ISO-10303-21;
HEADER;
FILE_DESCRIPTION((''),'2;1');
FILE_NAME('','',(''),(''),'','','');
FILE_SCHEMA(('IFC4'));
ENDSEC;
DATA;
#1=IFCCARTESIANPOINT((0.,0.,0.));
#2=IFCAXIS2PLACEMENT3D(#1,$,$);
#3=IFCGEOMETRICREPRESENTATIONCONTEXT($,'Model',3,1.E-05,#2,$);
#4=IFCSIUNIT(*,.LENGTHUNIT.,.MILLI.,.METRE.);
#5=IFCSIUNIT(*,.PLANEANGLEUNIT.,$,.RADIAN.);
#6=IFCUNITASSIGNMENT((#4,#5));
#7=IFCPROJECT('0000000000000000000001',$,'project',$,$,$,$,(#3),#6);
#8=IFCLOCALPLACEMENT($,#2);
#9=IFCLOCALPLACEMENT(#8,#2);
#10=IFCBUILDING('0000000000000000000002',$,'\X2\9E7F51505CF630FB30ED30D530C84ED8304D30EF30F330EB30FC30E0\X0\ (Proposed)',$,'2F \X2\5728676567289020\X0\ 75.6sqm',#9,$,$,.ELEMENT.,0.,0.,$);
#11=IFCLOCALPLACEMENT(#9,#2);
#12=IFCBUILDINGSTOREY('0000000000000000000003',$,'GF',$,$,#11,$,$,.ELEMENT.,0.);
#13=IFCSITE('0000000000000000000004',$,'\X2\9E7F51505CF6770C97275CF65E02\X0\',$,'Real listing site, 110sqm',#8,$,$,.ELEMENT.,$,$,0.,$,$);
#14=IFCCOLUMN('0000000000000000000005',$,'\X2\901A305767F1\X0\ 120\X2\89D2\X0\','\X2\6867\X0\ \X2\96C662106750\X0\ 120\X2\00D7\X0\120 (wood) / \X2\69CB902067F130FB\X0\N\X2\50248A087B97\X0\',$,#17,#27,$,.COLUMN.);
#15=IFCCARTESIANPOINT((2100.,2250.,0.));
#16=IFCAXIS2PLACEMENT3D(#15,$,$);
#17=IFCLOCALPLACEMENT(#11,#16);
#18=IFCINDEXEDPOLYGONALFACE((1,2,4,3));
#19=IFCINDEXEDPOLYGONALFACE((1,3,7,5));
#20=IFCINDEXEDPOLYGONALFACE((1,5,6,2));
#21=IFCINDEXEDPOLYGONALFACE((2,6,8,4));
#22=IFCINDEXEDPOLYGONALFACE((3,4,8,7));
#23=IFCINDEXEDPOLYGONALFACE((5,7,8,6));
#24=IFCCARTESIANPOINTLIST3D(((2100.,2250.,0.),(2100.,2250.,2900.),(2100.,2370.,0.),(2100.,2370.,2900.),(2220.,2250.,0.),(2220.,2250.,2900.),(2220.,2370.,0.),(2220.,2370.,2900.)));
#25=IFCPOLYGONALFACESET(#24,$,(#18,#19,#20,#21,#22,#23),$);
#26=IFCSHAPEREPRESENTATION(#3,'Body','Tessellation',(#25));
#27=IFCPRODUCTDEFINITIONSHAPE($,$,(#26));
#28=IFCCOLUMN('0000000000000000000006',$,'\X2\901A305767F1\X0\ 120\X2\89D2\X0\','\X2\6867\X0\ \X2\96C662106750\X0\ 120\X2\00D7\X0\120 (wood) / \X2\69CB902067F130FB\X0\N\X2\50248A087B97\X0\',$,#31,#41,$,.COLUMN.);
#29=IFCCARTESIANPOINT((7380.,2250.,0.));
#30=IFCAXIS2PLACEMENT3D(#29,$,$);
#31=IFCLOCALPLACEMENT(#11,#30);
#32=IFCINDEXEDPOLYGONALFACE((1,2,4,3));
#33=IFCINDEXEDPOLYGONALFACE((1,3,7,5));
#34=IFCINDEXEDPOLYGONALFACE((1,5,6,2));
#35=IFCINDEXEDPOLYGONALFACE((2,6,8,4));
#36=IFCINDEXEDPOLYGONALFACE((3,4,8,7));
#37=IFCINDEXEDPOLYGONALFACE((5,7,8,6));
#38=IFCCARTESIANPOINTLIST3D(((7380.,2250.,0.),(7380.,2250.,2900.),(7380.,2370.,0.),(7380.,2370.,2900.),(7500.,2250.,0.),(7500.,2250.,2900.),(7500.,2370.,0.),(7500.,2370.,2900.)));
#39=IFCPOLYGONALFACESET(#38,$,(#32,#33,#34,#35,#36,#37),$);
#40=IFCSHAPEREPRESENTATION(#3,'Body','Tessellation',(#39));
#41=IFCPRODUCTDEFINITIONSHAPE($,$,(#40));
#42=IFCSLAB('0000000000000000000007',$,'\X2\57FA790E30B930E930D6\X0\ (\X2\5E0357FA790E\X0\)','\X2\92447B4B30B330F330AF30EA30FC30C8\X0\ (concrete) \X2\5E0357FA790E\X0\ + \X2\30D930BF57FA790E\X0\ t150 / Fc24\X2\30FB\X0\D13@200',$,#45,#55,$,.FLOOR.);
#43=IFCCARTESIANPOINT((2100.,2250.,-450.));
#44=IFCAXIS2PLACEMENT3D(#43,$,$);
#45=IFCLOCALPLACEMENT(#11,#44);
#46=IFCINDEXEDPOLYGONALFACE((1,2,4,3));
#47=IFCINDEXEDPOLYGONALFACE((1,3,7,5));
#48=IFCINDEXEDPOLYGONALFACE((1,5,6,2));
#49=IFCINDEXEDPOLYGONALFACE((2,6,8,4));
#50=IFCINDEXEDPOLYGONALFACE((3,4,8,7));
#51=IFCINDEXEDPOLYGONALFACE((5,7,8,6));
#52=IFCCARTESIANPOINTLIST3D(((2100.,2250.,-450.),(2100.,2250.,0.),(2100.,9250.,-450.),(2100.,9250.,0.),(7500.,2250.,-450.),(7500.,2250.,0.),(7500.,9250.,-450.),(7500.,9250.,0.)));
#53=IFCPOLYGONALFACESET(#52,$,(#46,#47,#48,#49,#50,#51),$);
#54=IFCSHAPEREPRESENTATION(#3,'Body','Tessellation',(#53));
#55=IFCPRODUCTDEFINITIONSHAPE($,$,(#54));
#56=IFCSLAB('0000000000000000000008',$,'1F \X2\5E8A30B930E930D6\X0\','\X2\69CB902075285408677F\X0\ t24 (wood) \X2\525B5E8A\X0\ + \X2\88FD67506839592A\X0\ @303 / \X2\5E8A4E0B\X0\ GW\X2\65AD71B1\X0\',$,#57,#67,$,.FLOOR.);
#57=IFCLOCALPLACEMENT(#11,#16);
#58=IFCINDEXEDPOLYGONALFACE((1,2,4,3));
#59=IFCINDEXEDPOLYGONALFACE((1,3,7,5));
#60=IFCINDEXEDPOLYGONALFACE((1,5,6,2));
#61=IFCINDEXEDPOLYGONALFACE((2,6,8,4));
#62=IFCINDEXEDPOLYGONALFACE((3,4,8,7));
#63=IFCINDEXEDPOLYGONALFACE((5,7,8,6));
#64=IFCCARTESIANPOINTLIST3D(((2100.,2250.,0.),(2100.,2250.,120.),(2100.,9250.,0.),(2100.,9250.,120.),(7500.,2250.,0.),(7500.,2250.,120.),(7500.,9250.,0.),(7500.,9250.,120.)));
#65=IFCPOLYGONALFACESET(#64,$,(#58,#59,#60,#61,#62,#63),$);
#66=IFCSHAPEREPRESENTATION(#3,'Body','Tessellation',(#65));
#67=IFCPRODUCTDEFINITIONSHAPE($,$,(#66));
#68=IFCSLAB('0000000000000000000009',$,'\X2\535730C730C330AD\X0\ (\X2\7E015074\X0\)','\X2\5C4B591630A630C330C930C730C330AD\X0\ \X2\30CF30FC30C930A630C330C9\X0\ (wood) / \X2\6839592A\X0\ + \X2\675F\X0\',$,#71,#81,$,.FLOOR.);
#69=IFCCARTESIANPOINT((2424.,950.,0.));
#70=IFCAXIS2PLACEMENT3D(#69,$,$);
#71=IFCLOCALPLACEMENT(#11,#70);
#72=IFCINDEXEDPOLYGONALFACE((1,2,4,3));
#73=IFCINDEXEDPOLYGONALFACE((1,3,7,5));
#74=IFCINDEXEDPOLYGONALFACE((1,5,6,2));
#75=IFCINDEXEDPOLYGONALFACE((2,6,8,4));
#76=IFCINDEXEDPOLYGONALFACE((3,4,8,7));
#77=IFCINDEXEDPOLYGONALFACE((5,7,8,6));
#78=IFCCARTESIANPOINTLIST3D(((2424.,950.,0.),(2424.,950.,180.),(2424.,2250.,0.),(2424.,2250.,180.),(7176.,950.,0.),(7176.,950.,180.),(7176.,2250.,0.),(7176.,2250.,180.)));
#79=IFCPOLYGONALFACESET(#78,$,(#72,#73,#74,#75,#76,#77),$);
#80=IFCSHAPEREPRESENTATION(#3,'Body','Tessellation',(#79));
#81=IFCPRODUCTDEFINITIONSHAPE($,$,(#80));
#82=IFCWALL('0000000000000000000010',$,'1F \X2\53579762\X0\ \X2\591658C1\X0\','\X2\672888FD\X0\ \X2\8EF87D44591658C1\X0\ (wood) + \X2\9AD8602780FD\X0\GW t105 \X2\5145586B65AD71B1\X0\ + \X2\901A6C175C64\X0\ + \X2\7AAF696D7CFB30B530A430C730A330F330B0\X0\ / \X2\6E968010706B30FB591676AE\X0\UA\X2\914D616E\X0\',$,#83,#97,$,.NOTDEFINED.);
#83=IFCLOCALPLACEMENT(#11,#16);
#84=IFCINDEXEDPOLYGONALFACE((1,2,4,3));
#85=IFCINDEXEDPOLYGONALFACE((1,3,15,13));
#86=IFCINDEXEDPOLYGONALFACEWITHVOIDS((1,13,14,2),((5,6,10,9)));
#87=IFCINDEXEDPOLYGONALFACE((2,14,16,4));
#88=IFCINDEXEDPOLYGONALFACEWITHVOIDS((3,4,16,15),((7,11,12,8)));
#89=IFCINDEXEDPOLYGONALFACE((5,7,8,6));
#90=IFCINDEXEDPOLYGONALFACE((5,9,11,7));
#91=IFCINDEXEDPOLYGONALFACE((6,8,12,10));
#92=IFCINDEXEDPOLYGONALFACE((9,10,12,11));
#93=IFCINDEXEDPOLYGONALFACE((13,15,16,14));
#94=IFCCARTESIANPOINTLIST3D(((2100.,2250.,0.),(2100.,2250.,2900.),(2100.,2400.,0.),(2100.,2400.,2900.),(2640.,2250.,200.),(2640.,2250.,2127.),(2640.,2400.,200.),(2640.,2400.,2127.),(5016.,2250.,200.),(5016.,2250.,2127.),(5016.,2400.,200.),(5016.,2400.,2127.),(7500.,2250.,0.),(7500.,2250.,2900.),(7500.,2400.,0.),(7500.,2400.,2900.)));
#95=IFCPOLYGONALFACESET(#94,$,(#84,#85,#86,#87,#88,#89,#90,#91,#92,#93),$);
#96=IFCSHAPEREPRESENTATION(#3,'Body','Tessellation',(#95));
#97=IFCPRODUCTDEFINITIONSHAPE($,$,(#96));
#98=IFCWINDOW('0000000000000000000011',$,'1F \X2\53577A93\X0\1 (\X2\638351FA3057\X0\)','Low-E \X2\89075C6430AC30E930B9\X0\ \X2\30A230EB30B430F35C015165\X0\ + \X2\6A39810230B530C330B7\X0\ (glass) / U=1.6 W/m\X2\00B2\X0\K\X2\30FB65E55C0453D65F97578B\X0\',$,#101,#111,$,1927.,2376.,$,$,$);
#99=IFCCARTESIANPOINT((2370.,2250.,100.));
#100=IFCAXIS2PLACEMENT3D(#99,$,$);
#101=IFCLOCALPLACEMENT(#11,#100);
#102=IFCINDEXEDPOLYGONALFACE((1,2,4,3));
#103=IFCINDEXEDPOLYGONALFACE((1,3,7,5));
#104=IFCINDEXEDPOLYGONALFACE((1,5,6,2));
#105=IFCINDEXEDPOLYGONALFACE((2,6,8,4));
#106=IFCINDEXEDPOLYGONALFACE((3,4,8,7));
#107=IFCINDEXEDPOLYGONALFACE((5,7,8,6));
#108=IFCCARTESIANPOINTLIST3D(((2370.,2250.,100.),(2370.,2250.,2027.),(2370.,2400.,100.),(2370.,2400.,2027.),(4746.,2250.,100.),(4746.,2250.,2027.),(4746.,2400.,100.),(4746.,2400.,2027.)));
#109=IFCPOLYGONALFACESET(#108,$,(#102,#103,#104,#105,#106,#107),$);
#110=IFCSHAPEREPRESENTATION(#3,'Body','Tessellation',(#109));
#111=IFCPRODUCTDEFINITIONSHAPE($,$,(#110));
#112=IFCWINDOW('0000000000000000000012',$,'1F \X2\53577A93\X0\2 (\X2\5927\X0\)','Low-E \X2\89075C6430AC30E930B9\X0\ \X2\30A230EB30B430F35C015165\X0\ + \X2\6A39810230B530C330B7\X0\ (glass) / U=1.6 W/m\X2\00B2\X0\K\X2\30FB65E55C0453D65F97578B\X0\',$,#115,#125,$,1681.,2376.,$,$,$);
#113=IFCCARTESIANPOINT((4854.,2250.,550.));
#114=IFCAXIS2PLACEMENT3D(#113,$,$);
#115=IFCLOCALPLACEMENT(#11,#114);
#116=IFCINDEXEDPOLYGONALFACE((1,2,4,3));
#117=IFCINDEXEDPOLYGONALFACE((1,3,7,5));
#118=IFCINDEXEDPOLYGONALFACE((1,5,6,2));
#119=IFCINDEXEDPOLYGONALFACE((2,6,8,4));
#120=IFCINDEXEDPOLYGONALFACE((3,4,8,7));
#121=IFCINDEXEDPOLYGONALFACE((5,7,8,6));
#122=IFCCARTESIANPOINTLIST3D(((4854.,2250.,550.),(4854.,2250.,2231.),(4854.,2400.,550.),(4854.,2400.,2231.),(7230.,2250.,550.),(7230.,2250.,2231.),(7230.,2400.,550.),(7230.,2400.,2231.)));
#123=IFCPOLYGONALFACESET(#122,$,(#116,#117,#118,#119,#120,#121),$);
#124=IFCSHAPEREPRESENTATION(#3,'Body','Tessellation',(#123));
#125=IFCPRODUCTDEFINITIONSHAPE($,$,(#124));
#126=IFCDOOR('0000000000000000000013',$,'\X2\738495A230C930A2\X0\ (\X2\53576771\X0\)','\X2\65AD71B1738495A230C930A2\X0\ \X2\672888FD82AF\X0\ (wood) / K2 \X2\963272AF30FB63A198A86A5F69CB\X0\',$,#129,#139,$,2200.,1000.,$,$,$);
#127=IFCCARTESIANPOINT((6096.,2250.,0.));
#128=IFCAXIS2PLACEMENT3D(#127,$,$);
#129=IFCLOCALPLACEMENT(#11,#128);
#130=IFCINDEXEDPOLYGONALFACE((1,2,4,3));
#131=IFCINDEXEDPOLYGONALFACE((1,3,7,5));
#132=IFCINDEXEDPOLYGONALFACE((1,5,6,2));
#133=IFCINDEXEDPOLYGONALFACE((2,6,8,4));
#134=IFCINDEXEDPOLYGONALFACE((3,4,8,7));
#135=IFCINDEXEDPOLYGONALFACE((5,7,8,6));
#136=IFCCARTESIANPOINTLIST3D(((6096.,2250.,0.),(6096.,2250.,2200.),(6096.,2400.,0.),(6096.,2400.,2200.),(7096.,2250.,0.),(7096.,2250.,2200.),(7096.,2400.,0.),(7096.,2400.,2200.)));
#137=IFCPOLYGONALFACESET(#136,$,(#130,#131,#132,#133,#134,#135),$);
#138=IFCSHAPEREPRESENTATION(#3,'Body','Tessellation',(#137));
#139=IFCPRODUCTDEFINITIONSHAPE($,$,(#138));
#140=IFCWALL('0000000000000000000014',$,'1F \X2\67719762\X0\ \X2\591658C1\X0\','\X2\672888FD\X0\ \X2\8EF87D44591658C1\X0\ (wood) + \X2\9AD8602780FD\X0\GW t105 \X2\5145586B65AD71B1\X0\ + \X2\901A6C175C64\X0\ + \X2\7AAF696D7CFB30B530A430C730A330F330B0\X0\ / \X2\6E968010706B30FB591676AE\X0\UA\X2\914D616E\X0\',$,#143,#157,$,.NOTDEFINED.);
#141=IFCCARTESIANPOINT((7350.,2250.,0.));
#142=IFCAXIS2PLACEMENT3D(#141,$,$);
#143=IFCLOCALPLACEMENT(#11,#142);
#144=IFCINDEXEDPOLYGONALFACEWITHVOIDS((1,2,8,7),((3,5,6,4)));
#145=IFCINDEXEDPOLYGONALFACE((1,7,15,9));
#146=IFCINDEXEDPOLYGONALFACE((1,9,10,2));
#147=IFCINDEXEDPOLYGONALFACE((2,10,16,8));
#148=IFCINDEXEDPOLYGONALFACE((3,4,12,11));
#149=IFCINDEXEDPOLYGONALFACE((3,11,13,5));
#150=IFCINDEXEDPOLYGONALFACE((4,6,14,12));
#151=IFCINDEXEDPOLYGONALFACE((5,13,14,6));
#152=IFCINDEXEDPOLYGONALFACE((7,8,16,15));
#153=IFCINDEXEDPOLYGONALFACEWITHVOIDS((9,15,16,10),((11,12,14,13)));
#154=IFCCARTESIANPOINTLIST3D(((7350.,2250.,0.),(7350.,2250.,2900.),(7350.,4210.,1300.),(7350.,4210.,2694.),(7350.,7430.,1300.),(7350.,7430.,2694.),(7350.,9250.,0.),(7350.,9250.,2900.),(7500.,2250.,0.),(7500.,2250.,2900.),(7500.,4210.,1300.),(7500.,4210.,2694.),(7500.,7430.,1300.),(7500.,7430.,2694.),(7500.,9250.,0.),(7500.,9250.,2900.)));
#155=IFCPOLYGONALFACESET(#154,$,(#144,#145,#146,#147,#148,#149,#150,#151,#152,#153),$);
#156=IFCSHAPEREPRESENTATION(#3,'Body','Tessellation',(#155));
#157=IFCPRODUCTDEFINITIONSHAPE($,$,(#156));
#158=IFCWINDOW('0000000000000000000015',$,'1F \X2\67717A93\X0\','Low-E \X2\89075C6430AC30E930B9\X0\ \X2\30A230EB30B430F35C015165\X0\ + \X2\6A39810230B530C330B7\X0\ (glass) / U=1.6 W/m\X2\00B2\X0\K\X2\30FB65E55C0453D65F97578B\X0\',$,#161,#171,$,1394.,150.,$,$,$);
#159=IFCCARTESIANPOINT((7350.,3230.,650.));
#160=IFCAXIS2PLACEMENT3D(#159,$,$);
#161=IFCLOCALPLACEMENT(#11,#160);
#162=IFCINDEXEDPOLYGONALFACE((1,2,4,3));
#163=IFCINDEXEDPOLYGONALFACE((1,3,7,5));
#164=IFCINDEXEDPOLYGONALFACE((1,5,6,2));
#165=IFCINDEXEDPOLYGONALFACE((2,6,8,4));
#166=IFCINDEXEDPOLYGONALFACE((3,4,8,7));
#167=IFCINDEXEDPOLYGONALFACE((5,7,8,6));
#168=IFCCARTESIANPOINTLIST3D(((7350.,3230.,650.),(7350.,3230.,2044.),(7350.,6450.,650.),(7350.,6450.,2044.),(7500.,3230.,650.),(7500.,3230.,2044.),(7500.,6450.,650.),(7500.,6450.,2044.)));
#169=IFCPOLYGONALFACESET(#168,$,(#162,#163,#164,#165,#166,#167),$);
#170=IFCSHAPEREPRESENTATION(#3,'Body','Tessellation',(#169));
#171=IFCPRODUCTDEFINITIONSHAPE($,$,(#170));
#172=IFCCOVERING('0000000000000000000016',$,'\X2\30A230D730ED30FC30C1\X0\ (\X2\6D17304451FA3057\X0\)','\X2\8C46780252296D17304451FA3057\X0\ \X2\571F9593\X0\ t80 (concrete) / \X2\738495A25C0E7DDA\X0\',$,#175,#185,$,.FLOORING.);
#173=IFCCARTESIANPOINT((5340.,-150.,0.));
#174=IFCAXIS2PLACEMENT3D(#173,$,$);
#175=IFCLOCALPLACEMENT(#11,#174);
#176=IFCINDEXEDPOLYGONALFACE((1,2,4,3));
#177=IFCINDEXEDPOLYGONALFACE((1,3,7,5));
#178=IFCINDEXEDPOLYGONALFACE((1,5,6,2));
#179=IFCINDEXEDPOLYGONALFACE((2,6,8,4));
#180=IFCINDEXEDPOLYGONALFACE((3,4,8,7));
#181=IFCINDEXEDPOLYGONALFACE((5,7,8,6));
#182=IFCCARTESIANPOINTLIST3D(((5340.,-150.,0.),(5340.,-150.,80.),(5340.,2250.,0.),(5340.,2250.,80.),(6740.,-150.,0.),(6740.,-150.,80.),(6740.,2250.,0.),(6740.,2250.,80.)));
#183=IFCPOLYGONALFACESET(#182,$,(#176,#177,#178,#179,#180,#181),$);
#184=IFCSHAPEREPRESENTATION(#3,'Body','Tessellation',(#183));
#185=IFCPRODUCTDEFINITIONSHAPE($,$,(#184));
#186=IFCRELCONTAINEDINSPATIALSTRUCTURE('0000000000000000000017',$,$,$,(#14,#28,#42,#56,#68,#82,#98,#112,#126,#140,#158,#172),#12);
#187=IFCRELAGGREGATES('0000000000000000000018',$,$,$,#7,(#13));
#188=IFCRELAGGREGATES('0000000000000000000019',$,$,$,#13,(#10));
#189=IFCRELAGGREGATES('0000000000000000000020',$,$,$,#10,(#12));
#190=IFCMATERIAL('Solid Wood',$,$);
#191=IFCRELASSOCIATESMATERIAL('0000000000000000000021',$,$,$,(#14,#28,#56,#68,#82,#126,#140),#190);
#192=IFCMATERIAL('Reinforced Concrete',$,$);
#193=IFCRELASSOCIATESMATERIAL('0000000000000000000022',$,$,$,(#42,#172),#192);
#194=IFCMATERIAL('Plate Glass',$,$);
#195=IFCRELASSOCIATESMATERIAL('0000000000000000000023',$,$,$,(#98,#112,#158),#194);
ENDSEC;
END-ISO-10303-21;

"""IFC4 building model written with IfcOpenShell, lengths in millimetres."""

from ifc_helpers import new_model, si_unit, frame, frame_2d, origin, place, context, project, spatial, rectangle, extrude, material, element, fill, save


model = new_model("IFC4")

# Units and contexts
model_context = context("Model", 3, precision=1e-05, world=origin())
ifc_project = project(units=[si_unit("LENGTHUNIT", "METRE", prefix="MILLI"), si_unit("PLANEANGLEUNIT", "RADIAN")], contexts=[model_context])

# Site, building, storey
site_placement = place(None, origin())
site = spatial("IfcSite", under=ifc_project, at=site_placement, Name="鹿児島県霧島市", ObjectType="Real listing site, 110sqm", CompositionType="ELEMENT", RefElevation=0.0)
building_placement = place(site_placement, origin())
building = spatial("IfcBuilding", under=site, at=building_placement, Name="鹿児島・ロフト付きワンルーム (Proposed)", ObjectType="2F 在来木造 75.6sqm", CompositionType="ELEMENT", ElevationOfRefHeight=0.0, ElevationOfTerrain=0.0)
storey_placement = place(building_placement, origin())
storey = spatial("IfcBuildingStorey", under=building, at=storey_placement, Name="GF", CompositionType="ELEMENT", Elevation=0.0)

# Columns
ifc_material_1 = material(Name="Solid Wood")
column_1_placement = place(storey_placement, frame((2100.0, 2250.0, 0.0)))
element("IfcColumn", 1, at=column_1_placement, inside=storey, material=ifc_material_1, Name="通し柱 120角", Description="桧 集成材 120×120 (wood) / 構造柱・N値計算", PredefinedType="COLUMN", context=model_context, shape_type="SweptSolid", body=[
    extrude(rectangle(XDim=120.0, YDim=120.0, at=frame_2d((60.0, 60.0))), frame((2100.0, 2250.0, 0.0)), (0.0, 0.0, 1.0), 2900.0),
])
column_2_placement = place(storey_placement, frame((7380.0, 2250.0, 0.0)))
element("IfcColumn", 2, at=column_2_placement, inside=storey, material=ifc_material_1, Name="通し柱 120角", Description="桧 集成材 120×120 (wood) / 構造柱・N値計算", PredefinedType="COLUMN", context=model_context, shape_type="SweptSolid", body=[
    extrude(rectangle(XDim=120.0, YDim=120.0, at=frame_2d((60.0, 60.0))), frame((7380.0, 2250.0, 0.0)), (0.0, 0.0, 1.0), 2900.0),
])

# Slabs
ifc_material_2 = material(Name="Reinforced Concrete")
slab_1_placement = place(storey_placement, frame((2100.0, 2250.0, -450.0)))
element("IfcSlab", 3, at=slab_1_placement, inside=storey, material=ifc_material_2, Name="基礎スラブ (布基礎)", Description="鉄筋コンクリート (concrete) 布基礎 + ベタ基礎 t150 / Fc24・D13@200", PredefinedType="FLOOR", context=model_context, shape_type="SweptSolid", body=[
    extrude(rectangle(XDim=5400.0, YDim=7000.0, at=frame_2d((2700.0, 3500.0))), frame((2100.0, 2250.0, -450.0)), (0.0, 0.0, 1.0), 450.0),
])
slab_2_placement = place(storey_placement, frame((2100.0, 2250.0, 0.0)))
element("IfcSlab", 4, at=slab_2_placement, inside=storey, material=ifc_material_1, Name="1F 床スラブ", Description="構造用合板 t24 (wood) 剛床 + 製材根太 @303 / 床下 GW断熱", PredefinedType="FLOOR", context=model_context, shape_type="SweptSolid", body=[
    extrude(rectangle(XDim=5400.0, YDim=7000.0, at=frame_2d((2700.0, 3500.0))), frame((2100.0, 2250.0, 0.0)), (0.0, 0.0, 1.0), 120.0),
])
slab_3_placement = place(storey_placement, frame((2424.0, 950.0, 0.0)))
element("IfcSlab", 5, at=slab_3_placement, inside=storey, material=ifc_material_1, Name="南デッキ (縁側)", Description="屋外ウッドデッキ ハードウッド (wood) / 根太 + 束", PredefinedType="FLOOR", context=model_context, shape_type="SweptSolid", body=[
    extrude(rectangle(XDim=4752.0, YDim=1300.0, at=frame_2d((2376.0, 650.0))), frame((2424.0, 950.0, 0.0)), (0.0, 0.0, 1.0), 180.0),
])

# Wall, openings, windows, door
wall_1_placement = place(storey_placement, frame((2100.0, 2250.0, 0.0)))
wall_1 = element("IfcWall", 6, at=wall_1_placement, inside=storey, material=ifc_material_1, Name="1F 南面 外壁", Description="木製 軸組外壁 (wood) + 高性能GW t105 充填断熱 + 通気層 + 窯業系サイディング / 準耐火・外皮UA配慮", PredefinedType="NOTDEFINED", context=model_context, shape_type="SweptSolid", body=[
    extrude(rectangle(XDim=5400.0, YDim=150.0, at=frame_2d((2700.0, 75.0))), frame((2100.0, 2250.0, 0.0)), (0.0, 0.0, 1.0), 2900.0),
])
opening_1_placement = place(storey_placement, frame((2370.0, 2250.0, 100.0)))
opening_1 = element("IfcOpeningElement", 7, at=opening_1_placement, cuts=wall_1, PredefinedType="NOTDEFINED", context=model_context, shape_type="SweptSolid", body=[
    extrude(rectangle(XDim=2376.0, YDim=150.0, at=frame_2d((1188.0, 75.0))), frame((2370.0, 2250.0, 100.0)), (0.0, 0.0, 1.0), 1927.0),
])
opening_2_placement = place(storey_placement, frame((4854.0, 2250.0, 550.0)))
opening_2 = element("IfcOpeningElement", 8, at=opening_2_placement, cuts=wall_1, PredefinedType="NOTDEFINED", context=model_context, shape_type="SweptSolid", body=[
    extrude(rectangle(XDim=2376.0, YDim=150.0, at=frame_2d((1188.0, 75.0))), frame((4854.0, 2250.0, 550.0)), (0.0, 0.0, 1.0), 1681.0),
])
opening_3_placement = place(storey_placement, frame((6096.0, 2250.0, 0.0)))
opening_3 = element("IfcOpeningElement", 9, at=opening_3_placement, cuts=wall_1, PredefinedType="NOTDEFINED", context=model_context, shape_type="SweptSolid", body=[
    extrude(rectangle(XDim=1000.0, YDim=150.0, at=frame_2d((500.0, 75.0))), frame((6096.0, 2250.0, 0.0)), (0.0, 0.0, 1.0), 2200.0),
])
ifc_material_3 = material(Name="Plate Glass")
window_1_placement = place(storey_placement, frame((2370.0, 2250.0, 100.0)))
window_1 = element("IfcWindow", 10, at=window_1_placement, inside=storey, material=ifc_material_3, Name="1F 南窓1 (掃出し)", Description="Low-E 複層ガラス アルゴン封入 + 樹脂サッシ (glass) / U=1.6 W/m²K・日射取得型", OverallHeight=1927.0, OverallWidth=2376.0, context=model_context, shape_type="SweptSolid", body=[
    extrude(rectangle(XDim=2376.0, YDim=150.0, at=frame_2d((1188.0, 75.0))), frame((2370.0, 2250.0, 100.0)), (0.0, 0.0, 1.0), 1927.0),
])
fill(opening_1, window_1)
window_2_placement = place(storey_placement, frame((4854.0, 2250.0, 550.0)))
window_2 = element("IfcWindow", 11, at=window_2_placement, inside=storey, material=ifc_material_3, Name="1F 南窓2 (大)", Description="Low-E 複層ガラス アルゴン封入 + 樹脂サッシ (glass) / U=1.6 W/m²K・日射取得型", OverallHeight=1681.0, OverallWidth=2376.0, context=model_context, shape_type="SweptSolid", body=[
    extrude(rectangle(XDim=2376.0, YDim=150.0, at=frame_2d((1188.0, 75.0))), frame((4854.0, 2250.0, 550.0)), (0.0, 0.0, 1.0), 1681.0),
])
fill(opening_2, window_2)
door_placement = place(storey_placement, frame((6096.0, 2250.0, 0.0)))
door = element("IfcDoor", 12, at=door_placement, inside=storey, material=ifc_material_1, Name="玄関ドア (南東)", Description="断熱玄関ドア 木製芯 (wood) / K2 防犯・採風機構", OverallHeight=2200.0, OverallWidth=1000.0, context=model_context, shape_type="SweptSolid", body=[
    extrude(rectangle(XDim=1000.0, YDim=150.0, at=frame_2d((500.0, 75.0))), frame((6096.0, 2250.0, 0.0)), (0.0, 0.0, 1.0), 2200.0),
])
fill(opening_3, door)

# Wall, opening, window
wall_2_placement = place(storey_placement, frame((7350.0, 2250.0, 0.0)))
wall_2 = element("IfcWall", 13, at=wall_2_placement, inside=storey, material=ifc_material_1, Name="1F 東面 外壁", Description="木製 軸組外壁 (wood) + 高性能GW t105 充填断熱 + 通気層 + 窯業系サイディング / 準耐火・外皮UA配慮", PredefinedType="NOTDEFINED", context=model_context, shape_type="SweptSolid", body=[
    extrude(rectangle(XDim=150.0, YDim=7000.0, at=frame_2d((75.0, 3500.0))), frame((7350.0, 2250.0, 0.0)), (0.0, 0.0, 1.0), 2900.0),
])
opening_4_placement = place(storey_placement, frame((7350.0, 3230.0, 650.0)))
opening_4 = element("IfcOpeningElement", 14, at=opening_4_placement, cuts=wall_2, PredefinedType="NOTDEFINED", context=model_context, shape_type="SweptSolid", body=[
    extrude(rectangle(XDim=150.0, YDim=3220.0, at=frame_2d((75.0, 1610.0))), frame((7350.0, 3230.0, 650.0)), (0.0, 0.0, 1.0), 1394.0),
])
window_3_placement = place(storey_placement, frame((7350.0, 3230.0, 650.0)))
window_3 = element("IfcWindow", 15, at=window_3_placement, inside=storey, material=ifc_material_3, Name="1F 東窓", Description="Low-E 複層ガラス アルゴン封入 + 樹脂サッシ (glass) / U=1.6 W/m²K・日射取得型", OverallHeight=1394.0, OverallWidth=150.0, context=model_context, shape_type="SweptSolid", body=[
    extrude(rectangle(XDim=150.0, YDim=3220.0, at=frame_2d((75.0, 1610.0))), frame((7350.0, 3230.0, 650.0)), (0.0, 0.0, 1.0), 1394.0),
])
fill(opening_4, window_3)

# Covering
covering_1_placement = place(storey_placement, frame((5340.0, -150.0, 0.0)))
element("IfcCovering", 16, at=covering_1_placement, inside=storey, material=ifc_material_2, Name="アプローチ (洗い出し)", Description="豆砂利洗い出し 土間 t80 (concrete) / 玄関導線", PredefinedType="FLOORING", context=model_context, shape_type="SweptSolid", body=[
    extrude(rectangle(XDim=1400.0, YDim=2400.0, at=frame_2d((700.0, 1200.0))), frame((5340.0, -150.0, 0.0)), (0.0, 0.0, 1.0), 80.0),
])

save(model, "model.ifc")
